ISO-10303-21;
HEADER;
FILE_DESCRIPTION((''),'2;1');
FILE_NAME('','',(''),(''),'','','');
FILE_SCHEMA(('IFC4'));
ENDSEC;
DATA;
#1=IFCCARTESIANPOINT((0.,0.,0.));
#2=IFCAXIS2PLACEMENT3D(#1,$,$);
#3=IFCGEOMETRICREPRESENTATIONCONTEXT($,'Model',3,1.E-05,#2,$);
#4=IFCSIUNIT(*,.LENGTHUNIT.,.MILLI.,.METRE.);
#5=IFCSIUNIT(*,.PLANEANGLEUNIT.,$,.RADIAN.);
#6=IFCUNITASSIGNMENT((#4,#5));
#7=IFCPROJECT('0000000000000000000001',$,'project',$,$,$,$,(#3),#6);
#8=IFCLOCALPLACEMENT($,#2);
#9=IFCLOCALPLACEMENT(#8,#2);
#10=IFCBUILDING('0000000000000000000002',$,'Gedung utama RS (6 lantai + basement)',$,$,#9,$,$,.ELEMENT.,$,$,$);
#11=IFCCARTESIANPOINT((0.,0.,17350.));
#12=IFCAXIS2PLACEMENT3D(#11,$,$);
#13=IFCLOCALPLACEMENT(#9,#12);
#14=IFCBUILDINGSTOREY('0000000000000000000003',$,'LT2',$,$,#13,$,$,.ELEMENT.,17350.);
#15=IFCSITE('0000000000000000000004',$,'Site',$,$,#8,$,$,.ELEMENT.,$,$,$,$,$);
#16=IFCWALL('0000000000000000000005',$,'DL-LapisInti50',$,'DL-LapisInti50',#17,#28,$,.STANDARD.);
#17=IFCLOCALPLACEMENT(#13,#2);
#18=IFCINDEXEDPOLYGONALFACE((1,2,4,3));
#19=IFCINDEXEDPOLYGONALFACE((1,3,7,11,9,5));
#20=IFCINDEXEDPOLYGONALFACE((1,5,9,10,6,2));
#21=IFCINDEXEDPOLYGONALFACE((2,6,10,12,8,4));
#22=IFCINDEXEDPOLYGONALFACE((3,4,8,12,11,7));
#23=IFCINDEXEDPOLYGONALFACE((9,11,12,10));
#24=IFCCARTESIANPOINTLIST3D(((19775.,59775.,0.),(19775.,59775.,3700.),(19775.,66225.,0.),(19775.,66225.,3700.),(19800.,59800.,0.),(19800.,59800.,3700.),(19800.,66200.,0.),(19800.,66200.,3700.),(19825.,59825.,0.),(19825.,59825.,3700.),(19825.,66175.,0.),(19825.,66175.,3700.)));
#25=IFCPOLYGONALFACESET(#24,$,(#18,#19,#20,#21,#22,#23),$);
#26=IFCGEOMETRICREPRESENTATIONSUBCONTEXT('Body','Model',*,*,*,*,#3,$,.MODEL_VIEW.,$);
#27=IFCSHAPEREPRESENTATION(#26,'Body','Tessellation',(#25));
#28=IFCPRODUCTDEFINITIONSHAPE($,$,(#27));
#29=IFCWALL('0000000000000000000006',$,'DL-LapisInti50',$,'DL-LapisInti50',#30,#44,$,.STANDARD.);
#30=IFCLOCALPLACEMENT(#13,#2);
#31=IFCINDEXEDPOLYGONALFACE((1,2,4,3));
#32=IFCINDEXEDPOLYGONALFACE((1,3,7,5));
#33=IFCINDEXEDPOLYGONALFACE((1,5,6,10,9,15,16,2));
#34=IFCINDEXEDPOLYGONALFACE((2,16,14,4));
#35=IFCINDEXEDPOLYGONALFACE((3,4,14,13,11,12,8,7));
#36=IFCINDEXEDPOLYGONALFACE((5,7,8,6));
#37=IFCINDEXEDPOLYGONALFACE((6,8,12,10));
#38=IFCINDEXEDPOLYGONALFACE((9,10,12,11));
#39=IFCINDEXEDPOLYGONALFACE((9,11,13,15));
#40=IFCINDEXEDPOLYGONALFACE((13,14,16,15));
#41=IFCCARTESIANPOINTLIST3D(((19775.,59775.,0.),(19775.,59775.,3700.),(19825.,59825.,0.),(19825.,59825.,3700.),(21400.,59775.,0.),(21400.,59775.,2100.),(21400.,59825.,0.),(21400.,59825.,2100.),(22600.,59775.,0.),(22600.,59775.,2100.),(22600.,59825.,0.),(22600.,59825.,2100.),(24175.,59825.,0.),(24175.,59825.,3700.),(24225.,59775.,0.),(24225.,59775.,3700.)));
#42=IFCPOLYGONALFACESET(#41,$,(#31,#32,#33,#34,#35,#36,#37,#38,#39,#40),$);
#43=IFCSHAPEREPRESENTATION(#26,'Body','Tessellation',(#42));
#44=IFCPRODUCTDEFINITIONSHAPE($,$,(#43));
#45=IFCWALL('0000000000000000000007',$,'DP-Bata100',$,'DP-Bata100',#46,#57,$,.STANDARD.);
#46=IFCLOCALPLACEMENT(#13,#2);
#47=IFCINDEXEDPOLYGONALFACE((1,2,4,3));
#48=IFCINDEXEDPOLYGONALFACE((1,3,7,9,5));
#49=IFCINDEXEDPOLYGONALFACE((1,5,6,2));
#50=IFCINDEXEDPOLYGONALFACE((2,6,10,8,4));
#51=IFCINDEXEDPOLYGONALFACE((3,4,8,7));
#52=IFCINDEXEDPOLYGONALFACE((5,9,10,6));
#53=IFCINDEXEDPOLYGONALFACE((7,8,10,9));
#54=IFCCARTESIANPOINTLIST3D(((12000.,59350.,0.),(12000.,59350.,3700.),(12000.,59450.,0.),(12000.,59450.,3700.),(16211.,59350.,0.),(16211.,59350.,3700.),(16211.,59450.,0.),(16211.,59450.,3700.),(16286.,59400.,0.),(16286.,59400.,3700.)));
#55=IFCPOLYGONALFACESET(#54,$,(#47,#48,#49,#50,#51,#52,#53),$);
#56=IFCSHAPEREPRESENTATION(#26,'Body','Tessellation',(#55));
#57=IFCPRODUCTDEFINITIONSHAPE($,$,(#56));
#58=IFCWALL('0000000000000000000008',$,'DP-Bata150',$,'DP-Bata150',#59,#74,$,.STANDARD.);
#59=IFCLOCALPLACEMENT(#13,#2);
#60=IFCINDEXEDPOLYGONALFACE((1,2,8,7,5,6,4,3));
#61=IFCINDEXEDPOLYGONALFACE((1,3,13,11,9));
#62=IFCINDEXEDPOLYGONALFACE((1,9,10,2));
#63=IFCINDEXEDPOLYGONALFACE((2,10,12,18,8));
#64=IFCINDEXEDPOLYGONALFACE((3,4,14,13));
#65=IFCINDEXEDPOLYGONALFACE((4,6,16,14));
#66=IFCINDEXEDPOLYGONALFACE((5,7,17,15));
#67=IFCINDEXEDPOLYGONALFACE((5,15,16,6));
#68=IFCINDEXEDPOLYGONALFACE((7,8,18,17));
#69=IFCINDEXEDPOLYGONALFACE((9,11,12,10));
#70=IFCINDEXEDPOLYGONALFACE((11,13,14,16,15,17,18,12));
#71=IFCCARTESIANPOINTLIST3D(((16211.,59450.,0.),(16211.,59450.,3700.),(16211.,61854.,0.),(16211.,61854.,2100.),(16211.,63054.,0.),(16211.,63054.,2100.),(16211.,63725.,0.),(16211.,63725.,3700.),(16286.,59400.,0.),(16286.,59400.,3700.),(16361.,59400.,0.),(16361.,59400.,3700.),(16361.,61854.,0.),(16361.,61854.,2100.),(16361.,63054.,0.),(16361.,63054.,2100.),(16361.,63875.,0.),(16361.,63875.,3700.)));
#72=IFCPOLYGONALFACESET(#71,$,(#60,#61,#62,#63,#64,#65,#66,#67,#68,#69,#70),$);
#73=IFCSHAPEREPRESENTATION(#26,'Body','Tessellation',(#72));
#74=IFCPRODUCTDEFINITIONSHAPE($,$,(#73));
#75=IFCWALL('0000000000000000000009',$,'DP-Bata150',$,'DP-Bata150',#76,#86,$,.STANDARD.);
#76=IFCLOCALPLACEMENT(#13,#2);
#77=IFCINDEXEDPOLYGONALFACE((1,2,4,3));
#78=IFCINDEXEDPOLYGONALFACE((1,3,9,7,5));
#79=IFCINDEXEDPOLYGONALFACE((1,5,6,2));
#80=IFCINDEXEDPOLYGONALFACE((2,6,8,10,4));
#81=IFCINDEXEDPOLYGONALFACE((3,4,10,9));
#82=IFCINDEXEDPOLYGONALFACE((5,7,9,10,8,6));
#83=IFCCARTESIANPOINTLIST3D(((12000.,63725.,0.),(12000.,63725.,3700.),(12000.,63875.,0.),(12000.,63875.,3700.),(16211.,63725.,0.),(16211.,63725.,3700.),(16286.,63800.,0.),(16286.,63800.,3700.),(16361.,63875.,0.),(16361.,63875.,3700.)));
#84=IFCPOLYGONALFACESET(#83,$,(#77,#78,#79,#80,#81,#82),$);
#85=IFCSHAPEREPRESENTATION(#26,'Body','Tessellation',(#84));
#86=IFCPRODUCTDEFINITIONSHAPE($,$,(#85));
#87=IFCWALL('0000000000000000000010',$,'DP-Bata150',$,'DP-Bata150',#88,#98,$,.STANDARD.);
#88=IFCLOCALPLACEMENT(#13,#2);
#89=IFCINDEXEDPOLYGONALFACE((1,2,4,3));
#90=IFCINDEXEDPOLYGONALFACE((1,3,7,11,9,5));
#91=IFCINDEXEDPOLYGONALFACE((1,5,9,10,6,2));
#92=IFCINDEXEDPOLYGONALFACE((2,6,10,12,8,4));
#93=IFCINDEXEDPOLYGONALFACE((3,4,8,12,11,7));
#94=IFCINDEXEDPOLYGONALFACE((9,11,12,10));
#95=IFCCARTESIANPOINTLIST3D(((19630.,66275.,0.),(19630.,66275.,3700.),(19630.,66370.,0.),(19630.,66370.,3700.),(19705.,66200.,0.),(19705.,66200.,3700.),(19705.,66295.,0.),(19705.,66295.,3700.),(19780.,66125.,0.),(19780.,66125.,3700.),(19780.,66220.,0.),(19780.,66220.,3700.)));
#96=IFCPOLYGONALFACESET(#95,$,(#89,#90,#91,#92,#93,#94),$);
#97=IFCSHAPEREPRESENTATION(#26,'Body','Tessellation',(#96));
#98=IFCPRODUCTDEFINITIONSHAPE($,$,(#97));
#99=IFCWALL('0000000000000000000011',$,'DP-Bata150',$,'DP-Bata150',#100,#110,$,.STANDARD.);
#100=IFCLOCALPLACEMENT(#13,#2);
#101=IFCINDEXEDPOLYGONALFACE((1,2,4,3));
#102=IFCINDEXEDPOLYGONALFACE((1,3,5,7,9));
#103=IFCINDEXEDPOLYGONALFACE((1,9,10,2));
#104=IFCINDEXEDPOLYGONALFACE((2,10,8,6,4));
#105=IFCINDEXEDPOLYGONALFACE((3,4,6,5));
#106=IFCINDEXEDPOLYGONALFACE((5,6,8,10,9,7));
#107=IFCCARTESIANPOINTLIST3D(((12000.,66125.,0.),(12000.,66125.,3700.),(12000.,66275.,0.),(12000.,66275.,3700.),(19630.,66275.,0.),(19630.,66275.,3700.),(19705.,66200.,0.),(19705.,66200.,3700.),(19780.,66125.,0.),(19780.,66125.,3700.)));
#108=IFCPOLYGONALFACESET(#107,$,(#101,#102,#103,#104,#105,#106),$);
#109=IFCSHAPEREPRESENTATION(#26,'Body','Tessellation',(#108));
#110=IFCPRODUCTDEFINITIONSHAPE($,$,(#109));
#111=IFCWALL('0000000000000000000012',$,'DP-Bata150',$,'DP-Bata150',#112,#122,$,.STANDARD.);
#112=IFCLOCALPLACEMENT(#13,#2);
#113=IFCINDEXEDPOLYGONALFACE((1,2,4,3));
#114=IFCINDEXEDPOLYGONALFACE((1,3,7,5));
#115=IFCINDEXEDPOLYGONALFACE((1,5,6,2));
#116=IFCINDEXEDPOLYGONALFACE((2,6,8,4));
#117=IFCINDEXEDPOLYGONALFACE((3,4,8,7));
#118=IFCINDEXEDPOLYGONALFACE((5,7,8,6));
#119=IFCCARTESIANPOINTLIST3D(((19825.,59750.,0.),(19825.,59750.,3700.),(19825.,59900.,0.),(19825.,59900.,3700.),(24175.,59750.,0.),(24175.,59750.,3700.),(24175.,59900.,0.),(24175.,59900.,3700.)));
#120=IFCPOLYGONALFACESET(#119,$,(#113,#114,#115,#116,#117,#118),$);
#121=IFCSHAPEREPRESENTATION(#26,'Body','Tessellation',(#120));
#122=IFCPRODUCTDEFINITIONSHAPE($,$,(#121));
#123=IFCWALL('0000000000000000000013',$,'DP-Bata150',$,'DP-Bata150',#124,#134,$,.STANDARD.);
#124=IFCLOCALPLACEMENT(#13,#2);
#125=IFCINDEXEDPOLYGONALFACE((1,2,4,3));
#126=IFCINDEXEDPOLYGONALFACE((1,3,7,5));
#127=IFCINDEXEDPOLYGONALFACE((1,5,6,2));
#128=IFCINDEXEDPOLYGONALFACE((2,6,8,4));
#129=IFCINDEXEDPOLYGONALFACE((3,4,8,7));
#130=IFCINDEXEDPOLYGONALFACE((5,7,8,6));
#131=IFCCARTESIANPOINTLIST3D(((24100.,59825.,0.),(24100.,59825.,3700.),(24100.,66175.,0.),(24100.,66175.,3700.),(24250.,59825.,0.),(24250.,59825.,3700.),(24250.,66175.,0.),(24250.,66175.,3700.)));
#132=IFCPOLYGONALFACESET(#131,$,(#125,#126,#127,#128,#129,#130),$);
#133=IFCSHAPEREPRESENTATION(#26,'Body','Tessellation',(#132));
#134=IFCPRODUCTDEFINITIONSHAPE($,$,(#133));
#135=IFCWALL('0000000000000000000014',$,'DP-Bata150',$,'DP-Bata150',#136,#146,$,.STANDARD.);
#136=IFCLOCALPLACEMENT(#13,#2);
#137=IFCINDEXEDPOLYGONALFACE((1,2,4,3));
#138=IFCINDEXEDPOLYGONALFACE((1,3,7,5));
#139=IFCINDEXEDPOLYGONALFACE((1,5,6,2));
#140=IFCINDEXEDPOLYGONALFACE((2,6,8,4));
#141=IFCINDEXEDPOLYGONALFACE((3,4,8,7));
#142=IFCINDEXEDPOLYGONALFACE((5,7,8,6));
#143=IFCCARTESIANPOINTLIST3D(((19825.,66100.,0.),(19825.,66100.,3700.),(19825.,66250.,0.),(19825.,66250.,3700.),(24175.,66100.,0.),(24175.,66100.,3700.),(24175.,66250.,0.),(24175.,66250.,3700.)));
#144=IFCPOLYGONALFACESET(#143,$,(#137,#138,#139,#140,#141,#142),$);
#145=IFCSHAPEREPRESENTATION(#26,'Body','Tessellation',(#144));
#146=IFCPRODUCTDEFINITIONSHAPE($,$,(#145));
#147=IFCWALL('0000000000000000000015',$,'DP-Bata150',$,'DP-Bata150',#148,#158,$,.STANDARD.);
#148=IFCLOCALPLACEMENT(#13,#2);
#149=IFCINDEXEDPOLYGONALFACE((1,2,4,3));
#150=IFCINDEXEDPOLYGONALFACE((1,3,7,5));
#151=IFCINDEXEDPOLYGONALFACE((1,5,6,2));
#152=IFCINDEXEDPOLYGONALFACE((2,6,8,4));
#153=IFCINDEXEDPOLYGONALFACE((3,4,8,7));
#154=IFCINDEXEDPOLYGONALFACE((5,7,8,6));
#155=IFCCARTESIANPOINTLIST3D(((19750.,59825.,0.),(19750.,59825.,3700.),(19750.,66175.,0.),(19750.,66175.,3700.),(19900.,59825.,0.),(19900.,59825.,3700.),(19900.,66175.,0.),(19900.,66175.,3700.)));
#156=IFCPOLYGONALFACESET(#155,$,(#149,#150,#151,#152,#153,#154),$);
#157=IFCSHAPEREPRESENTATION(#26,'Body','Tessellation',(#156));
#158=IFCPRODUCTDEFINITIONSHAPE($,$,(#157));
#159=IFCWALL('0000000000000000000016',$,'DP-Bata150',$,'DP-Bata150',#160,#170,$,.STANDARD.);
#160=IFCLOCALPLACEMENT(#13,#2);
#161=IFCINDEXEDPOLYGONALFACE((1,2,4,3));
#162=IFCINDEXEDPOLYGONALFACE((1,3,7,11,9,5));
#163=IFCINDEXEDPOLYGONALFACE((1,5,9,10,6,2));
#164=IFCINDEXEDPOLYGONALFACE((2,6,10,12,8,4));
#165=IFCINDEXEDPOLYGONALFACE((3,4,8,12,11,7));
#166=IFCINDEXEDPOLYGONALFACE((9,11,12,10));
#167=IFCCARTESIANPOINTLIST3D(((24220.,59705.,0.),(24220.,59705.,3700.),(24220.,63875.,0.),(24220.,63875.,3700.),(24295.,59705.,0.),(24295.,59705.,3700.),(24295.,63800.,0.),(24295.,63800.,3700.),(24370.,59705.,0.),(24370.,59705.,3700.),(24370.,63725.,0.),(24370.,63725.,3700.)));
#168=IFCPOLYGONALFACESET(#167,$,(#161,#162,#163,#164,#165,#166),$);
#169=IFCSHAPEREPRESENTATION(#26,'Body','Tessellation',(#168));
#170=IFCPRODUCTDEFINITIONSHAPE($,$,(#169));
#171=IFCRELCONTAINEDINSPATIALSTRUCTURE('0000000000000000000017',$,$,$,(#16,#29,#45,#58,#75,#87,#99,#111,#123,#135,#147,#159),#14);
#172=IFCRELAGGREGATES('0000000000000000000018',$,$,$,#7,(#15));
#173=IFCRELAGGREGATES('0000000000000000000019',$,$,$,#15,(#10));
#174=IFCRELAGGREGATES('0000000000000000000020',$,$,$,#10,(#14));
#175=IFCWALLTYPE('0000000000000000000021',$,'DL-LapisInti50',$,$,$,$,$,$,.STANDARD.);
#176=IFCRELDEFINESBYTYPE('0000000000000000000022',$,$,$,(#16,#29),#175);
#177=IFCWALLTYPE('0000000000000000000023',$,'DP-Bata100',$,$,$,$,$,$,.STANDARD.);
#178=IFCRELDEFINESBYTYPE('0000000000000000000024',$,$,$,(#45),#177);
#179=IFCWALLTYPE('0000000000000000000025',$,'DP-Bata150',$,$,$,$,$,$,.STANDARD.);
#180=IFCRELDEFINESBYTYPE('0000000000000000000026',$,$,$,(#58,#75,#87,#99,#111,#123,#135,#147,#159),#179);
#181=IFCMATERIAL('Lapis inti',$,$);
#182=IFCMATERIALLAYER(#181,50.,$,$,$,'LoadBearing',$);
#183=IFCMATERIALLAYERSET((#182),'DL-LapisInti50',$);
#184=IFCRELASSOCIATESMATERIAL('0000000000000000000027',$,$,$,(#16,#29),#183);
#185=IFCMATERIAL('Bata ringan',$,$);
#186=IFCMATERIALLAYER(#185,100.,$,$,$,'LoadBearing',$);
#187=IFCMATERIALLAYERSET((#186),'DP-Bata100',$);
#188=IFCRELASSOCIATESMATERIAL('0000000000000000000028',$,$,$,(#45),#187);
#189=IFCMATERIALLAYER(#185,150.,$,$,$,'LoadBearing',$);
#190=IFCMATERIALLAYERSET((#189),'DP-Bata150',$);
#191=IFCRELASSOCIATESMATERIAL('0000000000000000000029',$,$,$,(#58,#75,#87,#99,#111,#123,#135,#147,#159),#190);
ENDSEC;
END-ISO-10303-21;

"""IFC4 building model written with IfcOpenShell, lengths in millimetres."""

from ifc_helpers import new_model, si_unit, frame, frame_2d, origin, place, context, subcontext, project, spatial, polyline, rectangle, outline, extrude, material, layer, layer_set, layer_usage, type_object, element, save


model = new_model("IFC4")

# Units and contexts
model_context = context("Model", 3, precision=1e-05, world=origin())
body_context = subcontext(model_context, "Body", "Model", "MODEL_VIEW")
ifc_project = project(units=[si_unit("LENGTHUNIT", "METRE", prefix="MILLI"), si_unit("PLANEANGLEUNIT", "RADIAN")], contexts=[model_context])

# Site, building, storey
site_placement = place(None, origin())
site = spatial("IfcSite", under=ifc_project, at=site_placement, Name="Site", CompositionType="ELEMENT")
building_placement = place(site_placement, origin())
building = spatial("IfcBuilding", under=site, at=building_placement, Name="Gedung utama RS (6 lantai + basement)", CompositionType="ELEMENT")
storey_placement = place(building_placement, frame((0.0, 0.0, 17350.0)))
storey = spatial("IfcBuildingStorey", under=building, at=storey_placement, Name="LT2", CompositionType="ELEMENT", Elevation=17350.0)

# Wall
ifc_material_1 = material(Name="Lapis inti")
ifc_layer_1 = layer(ifc_material_1, 50.0, Category="LoadBearing")
ifc_layer_set_1 = layer_set([ifc_layer_1], Name="DL-LapisInti50")
ifc_layer_usage_1 = layer_usage(ifc_layer_set_1, "AXIS2", "NEGATIVE", 25.0)
wall_type_1 = type_object("IfcWallType", Name="DL-LapisInti50", PredefinedType="STANDARD")
wall_1_placement = place(storey_placement, frame((19800.0, 66200.0, 0.0), z_axis=(0.0, 0.0, 1.0), x_axis=(0.0, -1.0, 0.0)))
element("IfcWall", 1, at=wall_1_placement, inside=storey, type_object=wall_type_1, material=ifc_layer_usage_1, Name="DL-LapisInti50", ObjectType="DL-LapisInti50", PredefinedType="STANDARD", context=body_context, shape_type="SweptSolid", body=[
    extrude(outline(polyline([(-25.0, -25.0), (0.0, 0.0), (25.0, 25.0), (6375.0, 25.0), (6400.0, 0.0), (6425.0, -25.0), (-25.0, -25.0)])), origin(), (0.0, 0.0, 1.0), 3700.0),
])

# Wall, opening
wall_2_placement = place(storey_placement, frame((19800.0, 59800.0, 0.0), z_axis=(0.0, 0.0, 1.0), x_axis=(1.0, 0.0, 0.0)))
wall_2 = element("IfcWall", 2, at=wall_2_placement, inside=storey, type_object=wall_type_1, material=ifc_layer_usage_1, Name="DL-LapisInti50", ObjectType="DL-LapisInti50", PredefinedType="STANDARD", context=body_context, shape_type="SweptSolid", body=[
    extrude(outline(polyline([(-25.0, -25.0), (0.0, 0.0), (25.0, 25.0), (4375.0, 25.0), (4400.0, 0.0), (4425.0, -25.0), (-25.0, -25.0)])), origin(), (0.0, 0.0, 1.0), 3700.0),
])
opening_1_placement = place(wall_2_placement, frame((1600.0, 0.0, 0.0), z_axis=(0.0, 0.0, 1.0), x_axis=(1.0, 0.0, 0.0)))
element("IfcOpeningElement", 3, at=opening_1_placement, cuts=wall_2, PredefinedType="OPENING", context=body_context, shape_type="SweptSolid", body=[
    extrude(rectangle(XDim=1200.0, YDim=70.0, at=frame_2d((600.0, 0.0))), origin(), (0.0, 0.0, 1.0), 2100.0),
])

# Wall
ifc_material_2 = material(Name="Bata ringan")
ifc_layer_2 = layer(ifc_material_2, 100.0, Category="LoadBearing")
ifc_layer_set_2 = layer_set([ifc_layer_2], Name="DP-Bata100")
ifc_layer_usage_2 = layer_usage(ifc_layer_set_2, "AXIS2", "NEGATIVE", 50.0)
wall_type_2 = type_object("IfcWallType", Name="DP-Bata100", PredefinedType="STANDARD")
wall_3_placement = place(storey_placement, frame((12000.0, 59400.0, 0.0), z_axis=(0.0, 0.0, 1.0), x_axis=(1.0, 0.0, 0.0)))
element("IfcWall", 4, at=wall_3_placement, inside=storey, type_object=wall_type_2, material=ifc_layer_usage_2, Name="DP-Bata100", ObjectType="DP-Bata100", PredefinedType="STANDARD", context=body_context, shape_type="SweptSolid", body=[
    extrude(outline(polyline([(0.0, -50.0), (0.0, 50.0), (4211.0, 50.0), (4286.0, 0.0), (4211.0, -50.0), (0.0, -50.0)])), origin(), (0.0, 0.0, 1.0), 3700.0),
])

# Wall, opening
ifc_layer_3 = layer(ifc_material_2, 150.0, Category="LoadBearing")
ifc_layer_set_3 = layer_set([ifc_layer_3], Name="DP-Bata150")
ifc_layer_usage_3 = layer_usage(ifc_layer_set_3, "AXIS2", "NEGATIVE", 75.0)
wall_type_3 = type_object("IfcWallType", Name="DP-Bata150", PredefinedType="STANDARD")
wall_4_placement = place(storey_placement, frame((16286.0, 59400.0, 0.0), z_axis=(0.0, 0.0, 1.0), x_axis=(0.0, 1.0, 0.0)))
wall_4 = element("IfcWall", 5, at=wall_4_placement, inside=storey, type_object=wall_type_3, material=ifc_layer_usage_3, Name="DP-Bata150", ObjectType="DP-Bata150", PredefinedType="STANDARD", context=body_context, shape_type="SweptSolid", body=[
    extrude(outline(polyline([(0.0, -75.0), (0.0, 0.0), (50.0, 75.0), (4325.0, 75.0), (4400.0, 0.0), (4475.0, -75.0), (0.0, -75.0)])), origin(), (0.0, 0.0, 1.0), 3700.0),
])
opening_2_placement = place(wall_4_placement, frame((2454.0, 0.0, 0.0), z_axis=(0.0, 0.0, 1.0), x_axis=(1.0, 0.0, 0.0)))
element("IfcOpeningElement", 6, at=opening_2_placement, cuts=wall_4, PredefinedType="OPENING", context=body_context, shape_type="SweptSolid", body=[
    extrude(rectangle(XDim=1200.0, YDim=170.0, at=frame_2d((600.0, 0.0))), origin(), (0.0, 0.0, 1.0), 2100.0),
])

# Walls
wall_5_placement = place(storey_placement, frame((16286.0, 63800.0, 0.0), z_axis=(0.0, 0.0, 1.0), x_axis=(-1.0, 0.0, 0.0)))
element("IfcWall", 7, at=wall_5_placement, inside=storey, type_object=wall_type_3, material=ifc_layer_usage_3, Name="DP-Bata150", ObjectType="DP-Bata150", PredefinedType="STANDARD", context=body_context, shape_type="SweptSolid", body=[
    extrude(outline(polyline([(-75.0, -75.0), (0.0, 0.0), (75.0, 75.0), (4286.0, 75.0), (4286.0, -75.0), (-75.0, -75.0)])), origin(), (0.0, 0.0, 1.0), 3700.0),
])
wall_6_placement = place(storey_placement, frame((19705.0, 66295.0, 0.0), z_axis=(0.0, 0.0, 1.0), x_axis=(0.0, -1.0, 0.0)))
element("IfcWall", 8, at=wall_6_placement, inside=storey, type_object=wall_type_3, material=ifc_layer_usage_3, Name="DP-Bata150", ObjectType="DP-Bata150", PredefinedType="STANDARD", context=body_context, shape_type="SweptSolid", body=[
    extrude(outline(polyline([(-75.0, -75.0), (0.0, 0.0), (75.0, 75.0), (170.0, 75.0), (95.0, 0.0), (20.0, -75.0), (-75.0, -75.0)])), origin(), (0.0, 0.0, 1.0), 3700.0),
])
wall_7_placement = place(storey_placement, frame((19705.0, 66200.0, 0.0), z_axis=(0.0, 0.0, 1.0), x_axis=(-1.0, 0.0, 0.0)))
element("IfcWall", 9, at=wall_7_placement, inside=storey, type_object=wall_type_3, material=ifc_layer_usage_3, Name="DP-Bata150", ObjectType="DP-Bata150", PredefinedType="STANDARD", context=body_context, shape_type="SweptSolid", body=[
    extrude(outline(polyline([(75.0, -75.0), (0.0, 0.0), (-75.0, 75.0), (7705.0, 75.0), (7705.0, -75.0), (75.0, -75.0)])), origin(), (0.0, 0.0, 1.0), 3700.0),
])
wall_8_placement = place(storey_placement, frame((19825.0, 59825.0, 0.0), z_axis=(0.0, 0.0, 1.0), x_axis=(1.0, 0.0, 0.0)))
element("IfcWall", 10, at=wall_8_placement, inside=storey, type_object=wall_type_3, material=ifc_layer_usage_3, Name="DP-Bata150", ObjectType="DP-Bata150", PredefinedType="STANDARD", context=body_context, shape_type="SweptSolid", body=[
    extrude(outline(polyline([(0.0, -75.0), (0.0, 75.0), (4350.0, 75.0), (4350.0, -75.0), (0.0, -75.0)])), origin(), (0.0, 0.0, 1.0), 3700.0),
])
wall_9_placement = place(storey_placement, frame((24175.0, 59825.0, 0.0), z_axis=(0.0, 0.0, 1.0), x_axis=(0.0, 1.0, 0.0)))
element("IfcWall", 11, at=wall_9_placement, inside=storey, type_object=wall_type_3, material=ifc_layer_usage_3, Name="DP-Bata150", ObjectType="DP-Bata150", PredefinedType="STANDARD", context=body_context, shape_type="SweptSolid", body=[
    extrude(outline(polyline([(0.0, -75.0), (0.0, 75.0), (6350.0, 75.0), (6350.0, -75.0), (0.0, -75.0)])), origin(), (0.0, 0.0, 1.0), 3700.0),
])
wall_10_placement = place(storey_placement, frame((24175.0, 66175.0, 0.0), z_axis=(0.0, 0.0, 1.0), x_axis=(-1.0, 0.0, 0.0)))
element("IfcWall", 12, at=wall_10_placement, inside=storey, type_object=wall_type_3, material=ifc_layer_usage_3, Name="DP-Bata150", ObjectType="DP-Bata150", PredefinedType="STANDARD", context=body_context, shape_type="SweptSolid", body=[
    extrude(outline(polyline([(0.0, -75.0), (0.0, 75.0), (4350.0, 75.0), (4350.0, -75.0), (0.0, -75.0)])), origin(), (0.0, 0.0, 1.0), 3700.0),
])
wall_11_placement = place(storey_placement, frame((19825.0, 66175.0, 0.0), z_axis=(0.0, 0.0, 1.0), x_axis=(0.0, -1.0, 0.0)))
element("IfcWall", 13, at=wall_11_placement, inside=storey, type_object=wall_type_3, material=ifc_layer_usage_3, Name="DP-Bata150", ObjectType="DP-Bata150", PredefinedType="STANDARD", context=body_context, shape_type="SweptSolid", body=[
    extrude(outline(polyline([(0.0, -75.0), (0.0, 75.0), (6350.0, 75.0), (6350.0, -75.0), (0.0, -75.0)])), origin(), (0.0, 0.0, 1.0), 3700.0),
])
wall_12_placement = place(storey_placement, frame((24295.0, 59705.0, 0.0), z_axis=(0.0, 0.0, 1.0), x_axis=(0.0, 1.0, 0.0)))
element("IfcWall", 14, at=wall_12_placement, inside=storey, type_object=wall_type_3, material=ifc_layer_usage_3, Name="DP-Bata150", ObjectType="DP-Bata150", PredefinedType="STANDARD", context=body_context, shape_type="SweptSolid", body=[
    extrude(outline(polyline([(0.0, -75.0), (0.0, 0.0), (0.0, 75.0), (4170.0, 75.0), (4095.0, 0.0), (4020.0, -75.0), (0.0, -75.0)])), origin(), (0.0, 0.0, 1.0), 3700.0),
])

save(model, "model.ifc")
